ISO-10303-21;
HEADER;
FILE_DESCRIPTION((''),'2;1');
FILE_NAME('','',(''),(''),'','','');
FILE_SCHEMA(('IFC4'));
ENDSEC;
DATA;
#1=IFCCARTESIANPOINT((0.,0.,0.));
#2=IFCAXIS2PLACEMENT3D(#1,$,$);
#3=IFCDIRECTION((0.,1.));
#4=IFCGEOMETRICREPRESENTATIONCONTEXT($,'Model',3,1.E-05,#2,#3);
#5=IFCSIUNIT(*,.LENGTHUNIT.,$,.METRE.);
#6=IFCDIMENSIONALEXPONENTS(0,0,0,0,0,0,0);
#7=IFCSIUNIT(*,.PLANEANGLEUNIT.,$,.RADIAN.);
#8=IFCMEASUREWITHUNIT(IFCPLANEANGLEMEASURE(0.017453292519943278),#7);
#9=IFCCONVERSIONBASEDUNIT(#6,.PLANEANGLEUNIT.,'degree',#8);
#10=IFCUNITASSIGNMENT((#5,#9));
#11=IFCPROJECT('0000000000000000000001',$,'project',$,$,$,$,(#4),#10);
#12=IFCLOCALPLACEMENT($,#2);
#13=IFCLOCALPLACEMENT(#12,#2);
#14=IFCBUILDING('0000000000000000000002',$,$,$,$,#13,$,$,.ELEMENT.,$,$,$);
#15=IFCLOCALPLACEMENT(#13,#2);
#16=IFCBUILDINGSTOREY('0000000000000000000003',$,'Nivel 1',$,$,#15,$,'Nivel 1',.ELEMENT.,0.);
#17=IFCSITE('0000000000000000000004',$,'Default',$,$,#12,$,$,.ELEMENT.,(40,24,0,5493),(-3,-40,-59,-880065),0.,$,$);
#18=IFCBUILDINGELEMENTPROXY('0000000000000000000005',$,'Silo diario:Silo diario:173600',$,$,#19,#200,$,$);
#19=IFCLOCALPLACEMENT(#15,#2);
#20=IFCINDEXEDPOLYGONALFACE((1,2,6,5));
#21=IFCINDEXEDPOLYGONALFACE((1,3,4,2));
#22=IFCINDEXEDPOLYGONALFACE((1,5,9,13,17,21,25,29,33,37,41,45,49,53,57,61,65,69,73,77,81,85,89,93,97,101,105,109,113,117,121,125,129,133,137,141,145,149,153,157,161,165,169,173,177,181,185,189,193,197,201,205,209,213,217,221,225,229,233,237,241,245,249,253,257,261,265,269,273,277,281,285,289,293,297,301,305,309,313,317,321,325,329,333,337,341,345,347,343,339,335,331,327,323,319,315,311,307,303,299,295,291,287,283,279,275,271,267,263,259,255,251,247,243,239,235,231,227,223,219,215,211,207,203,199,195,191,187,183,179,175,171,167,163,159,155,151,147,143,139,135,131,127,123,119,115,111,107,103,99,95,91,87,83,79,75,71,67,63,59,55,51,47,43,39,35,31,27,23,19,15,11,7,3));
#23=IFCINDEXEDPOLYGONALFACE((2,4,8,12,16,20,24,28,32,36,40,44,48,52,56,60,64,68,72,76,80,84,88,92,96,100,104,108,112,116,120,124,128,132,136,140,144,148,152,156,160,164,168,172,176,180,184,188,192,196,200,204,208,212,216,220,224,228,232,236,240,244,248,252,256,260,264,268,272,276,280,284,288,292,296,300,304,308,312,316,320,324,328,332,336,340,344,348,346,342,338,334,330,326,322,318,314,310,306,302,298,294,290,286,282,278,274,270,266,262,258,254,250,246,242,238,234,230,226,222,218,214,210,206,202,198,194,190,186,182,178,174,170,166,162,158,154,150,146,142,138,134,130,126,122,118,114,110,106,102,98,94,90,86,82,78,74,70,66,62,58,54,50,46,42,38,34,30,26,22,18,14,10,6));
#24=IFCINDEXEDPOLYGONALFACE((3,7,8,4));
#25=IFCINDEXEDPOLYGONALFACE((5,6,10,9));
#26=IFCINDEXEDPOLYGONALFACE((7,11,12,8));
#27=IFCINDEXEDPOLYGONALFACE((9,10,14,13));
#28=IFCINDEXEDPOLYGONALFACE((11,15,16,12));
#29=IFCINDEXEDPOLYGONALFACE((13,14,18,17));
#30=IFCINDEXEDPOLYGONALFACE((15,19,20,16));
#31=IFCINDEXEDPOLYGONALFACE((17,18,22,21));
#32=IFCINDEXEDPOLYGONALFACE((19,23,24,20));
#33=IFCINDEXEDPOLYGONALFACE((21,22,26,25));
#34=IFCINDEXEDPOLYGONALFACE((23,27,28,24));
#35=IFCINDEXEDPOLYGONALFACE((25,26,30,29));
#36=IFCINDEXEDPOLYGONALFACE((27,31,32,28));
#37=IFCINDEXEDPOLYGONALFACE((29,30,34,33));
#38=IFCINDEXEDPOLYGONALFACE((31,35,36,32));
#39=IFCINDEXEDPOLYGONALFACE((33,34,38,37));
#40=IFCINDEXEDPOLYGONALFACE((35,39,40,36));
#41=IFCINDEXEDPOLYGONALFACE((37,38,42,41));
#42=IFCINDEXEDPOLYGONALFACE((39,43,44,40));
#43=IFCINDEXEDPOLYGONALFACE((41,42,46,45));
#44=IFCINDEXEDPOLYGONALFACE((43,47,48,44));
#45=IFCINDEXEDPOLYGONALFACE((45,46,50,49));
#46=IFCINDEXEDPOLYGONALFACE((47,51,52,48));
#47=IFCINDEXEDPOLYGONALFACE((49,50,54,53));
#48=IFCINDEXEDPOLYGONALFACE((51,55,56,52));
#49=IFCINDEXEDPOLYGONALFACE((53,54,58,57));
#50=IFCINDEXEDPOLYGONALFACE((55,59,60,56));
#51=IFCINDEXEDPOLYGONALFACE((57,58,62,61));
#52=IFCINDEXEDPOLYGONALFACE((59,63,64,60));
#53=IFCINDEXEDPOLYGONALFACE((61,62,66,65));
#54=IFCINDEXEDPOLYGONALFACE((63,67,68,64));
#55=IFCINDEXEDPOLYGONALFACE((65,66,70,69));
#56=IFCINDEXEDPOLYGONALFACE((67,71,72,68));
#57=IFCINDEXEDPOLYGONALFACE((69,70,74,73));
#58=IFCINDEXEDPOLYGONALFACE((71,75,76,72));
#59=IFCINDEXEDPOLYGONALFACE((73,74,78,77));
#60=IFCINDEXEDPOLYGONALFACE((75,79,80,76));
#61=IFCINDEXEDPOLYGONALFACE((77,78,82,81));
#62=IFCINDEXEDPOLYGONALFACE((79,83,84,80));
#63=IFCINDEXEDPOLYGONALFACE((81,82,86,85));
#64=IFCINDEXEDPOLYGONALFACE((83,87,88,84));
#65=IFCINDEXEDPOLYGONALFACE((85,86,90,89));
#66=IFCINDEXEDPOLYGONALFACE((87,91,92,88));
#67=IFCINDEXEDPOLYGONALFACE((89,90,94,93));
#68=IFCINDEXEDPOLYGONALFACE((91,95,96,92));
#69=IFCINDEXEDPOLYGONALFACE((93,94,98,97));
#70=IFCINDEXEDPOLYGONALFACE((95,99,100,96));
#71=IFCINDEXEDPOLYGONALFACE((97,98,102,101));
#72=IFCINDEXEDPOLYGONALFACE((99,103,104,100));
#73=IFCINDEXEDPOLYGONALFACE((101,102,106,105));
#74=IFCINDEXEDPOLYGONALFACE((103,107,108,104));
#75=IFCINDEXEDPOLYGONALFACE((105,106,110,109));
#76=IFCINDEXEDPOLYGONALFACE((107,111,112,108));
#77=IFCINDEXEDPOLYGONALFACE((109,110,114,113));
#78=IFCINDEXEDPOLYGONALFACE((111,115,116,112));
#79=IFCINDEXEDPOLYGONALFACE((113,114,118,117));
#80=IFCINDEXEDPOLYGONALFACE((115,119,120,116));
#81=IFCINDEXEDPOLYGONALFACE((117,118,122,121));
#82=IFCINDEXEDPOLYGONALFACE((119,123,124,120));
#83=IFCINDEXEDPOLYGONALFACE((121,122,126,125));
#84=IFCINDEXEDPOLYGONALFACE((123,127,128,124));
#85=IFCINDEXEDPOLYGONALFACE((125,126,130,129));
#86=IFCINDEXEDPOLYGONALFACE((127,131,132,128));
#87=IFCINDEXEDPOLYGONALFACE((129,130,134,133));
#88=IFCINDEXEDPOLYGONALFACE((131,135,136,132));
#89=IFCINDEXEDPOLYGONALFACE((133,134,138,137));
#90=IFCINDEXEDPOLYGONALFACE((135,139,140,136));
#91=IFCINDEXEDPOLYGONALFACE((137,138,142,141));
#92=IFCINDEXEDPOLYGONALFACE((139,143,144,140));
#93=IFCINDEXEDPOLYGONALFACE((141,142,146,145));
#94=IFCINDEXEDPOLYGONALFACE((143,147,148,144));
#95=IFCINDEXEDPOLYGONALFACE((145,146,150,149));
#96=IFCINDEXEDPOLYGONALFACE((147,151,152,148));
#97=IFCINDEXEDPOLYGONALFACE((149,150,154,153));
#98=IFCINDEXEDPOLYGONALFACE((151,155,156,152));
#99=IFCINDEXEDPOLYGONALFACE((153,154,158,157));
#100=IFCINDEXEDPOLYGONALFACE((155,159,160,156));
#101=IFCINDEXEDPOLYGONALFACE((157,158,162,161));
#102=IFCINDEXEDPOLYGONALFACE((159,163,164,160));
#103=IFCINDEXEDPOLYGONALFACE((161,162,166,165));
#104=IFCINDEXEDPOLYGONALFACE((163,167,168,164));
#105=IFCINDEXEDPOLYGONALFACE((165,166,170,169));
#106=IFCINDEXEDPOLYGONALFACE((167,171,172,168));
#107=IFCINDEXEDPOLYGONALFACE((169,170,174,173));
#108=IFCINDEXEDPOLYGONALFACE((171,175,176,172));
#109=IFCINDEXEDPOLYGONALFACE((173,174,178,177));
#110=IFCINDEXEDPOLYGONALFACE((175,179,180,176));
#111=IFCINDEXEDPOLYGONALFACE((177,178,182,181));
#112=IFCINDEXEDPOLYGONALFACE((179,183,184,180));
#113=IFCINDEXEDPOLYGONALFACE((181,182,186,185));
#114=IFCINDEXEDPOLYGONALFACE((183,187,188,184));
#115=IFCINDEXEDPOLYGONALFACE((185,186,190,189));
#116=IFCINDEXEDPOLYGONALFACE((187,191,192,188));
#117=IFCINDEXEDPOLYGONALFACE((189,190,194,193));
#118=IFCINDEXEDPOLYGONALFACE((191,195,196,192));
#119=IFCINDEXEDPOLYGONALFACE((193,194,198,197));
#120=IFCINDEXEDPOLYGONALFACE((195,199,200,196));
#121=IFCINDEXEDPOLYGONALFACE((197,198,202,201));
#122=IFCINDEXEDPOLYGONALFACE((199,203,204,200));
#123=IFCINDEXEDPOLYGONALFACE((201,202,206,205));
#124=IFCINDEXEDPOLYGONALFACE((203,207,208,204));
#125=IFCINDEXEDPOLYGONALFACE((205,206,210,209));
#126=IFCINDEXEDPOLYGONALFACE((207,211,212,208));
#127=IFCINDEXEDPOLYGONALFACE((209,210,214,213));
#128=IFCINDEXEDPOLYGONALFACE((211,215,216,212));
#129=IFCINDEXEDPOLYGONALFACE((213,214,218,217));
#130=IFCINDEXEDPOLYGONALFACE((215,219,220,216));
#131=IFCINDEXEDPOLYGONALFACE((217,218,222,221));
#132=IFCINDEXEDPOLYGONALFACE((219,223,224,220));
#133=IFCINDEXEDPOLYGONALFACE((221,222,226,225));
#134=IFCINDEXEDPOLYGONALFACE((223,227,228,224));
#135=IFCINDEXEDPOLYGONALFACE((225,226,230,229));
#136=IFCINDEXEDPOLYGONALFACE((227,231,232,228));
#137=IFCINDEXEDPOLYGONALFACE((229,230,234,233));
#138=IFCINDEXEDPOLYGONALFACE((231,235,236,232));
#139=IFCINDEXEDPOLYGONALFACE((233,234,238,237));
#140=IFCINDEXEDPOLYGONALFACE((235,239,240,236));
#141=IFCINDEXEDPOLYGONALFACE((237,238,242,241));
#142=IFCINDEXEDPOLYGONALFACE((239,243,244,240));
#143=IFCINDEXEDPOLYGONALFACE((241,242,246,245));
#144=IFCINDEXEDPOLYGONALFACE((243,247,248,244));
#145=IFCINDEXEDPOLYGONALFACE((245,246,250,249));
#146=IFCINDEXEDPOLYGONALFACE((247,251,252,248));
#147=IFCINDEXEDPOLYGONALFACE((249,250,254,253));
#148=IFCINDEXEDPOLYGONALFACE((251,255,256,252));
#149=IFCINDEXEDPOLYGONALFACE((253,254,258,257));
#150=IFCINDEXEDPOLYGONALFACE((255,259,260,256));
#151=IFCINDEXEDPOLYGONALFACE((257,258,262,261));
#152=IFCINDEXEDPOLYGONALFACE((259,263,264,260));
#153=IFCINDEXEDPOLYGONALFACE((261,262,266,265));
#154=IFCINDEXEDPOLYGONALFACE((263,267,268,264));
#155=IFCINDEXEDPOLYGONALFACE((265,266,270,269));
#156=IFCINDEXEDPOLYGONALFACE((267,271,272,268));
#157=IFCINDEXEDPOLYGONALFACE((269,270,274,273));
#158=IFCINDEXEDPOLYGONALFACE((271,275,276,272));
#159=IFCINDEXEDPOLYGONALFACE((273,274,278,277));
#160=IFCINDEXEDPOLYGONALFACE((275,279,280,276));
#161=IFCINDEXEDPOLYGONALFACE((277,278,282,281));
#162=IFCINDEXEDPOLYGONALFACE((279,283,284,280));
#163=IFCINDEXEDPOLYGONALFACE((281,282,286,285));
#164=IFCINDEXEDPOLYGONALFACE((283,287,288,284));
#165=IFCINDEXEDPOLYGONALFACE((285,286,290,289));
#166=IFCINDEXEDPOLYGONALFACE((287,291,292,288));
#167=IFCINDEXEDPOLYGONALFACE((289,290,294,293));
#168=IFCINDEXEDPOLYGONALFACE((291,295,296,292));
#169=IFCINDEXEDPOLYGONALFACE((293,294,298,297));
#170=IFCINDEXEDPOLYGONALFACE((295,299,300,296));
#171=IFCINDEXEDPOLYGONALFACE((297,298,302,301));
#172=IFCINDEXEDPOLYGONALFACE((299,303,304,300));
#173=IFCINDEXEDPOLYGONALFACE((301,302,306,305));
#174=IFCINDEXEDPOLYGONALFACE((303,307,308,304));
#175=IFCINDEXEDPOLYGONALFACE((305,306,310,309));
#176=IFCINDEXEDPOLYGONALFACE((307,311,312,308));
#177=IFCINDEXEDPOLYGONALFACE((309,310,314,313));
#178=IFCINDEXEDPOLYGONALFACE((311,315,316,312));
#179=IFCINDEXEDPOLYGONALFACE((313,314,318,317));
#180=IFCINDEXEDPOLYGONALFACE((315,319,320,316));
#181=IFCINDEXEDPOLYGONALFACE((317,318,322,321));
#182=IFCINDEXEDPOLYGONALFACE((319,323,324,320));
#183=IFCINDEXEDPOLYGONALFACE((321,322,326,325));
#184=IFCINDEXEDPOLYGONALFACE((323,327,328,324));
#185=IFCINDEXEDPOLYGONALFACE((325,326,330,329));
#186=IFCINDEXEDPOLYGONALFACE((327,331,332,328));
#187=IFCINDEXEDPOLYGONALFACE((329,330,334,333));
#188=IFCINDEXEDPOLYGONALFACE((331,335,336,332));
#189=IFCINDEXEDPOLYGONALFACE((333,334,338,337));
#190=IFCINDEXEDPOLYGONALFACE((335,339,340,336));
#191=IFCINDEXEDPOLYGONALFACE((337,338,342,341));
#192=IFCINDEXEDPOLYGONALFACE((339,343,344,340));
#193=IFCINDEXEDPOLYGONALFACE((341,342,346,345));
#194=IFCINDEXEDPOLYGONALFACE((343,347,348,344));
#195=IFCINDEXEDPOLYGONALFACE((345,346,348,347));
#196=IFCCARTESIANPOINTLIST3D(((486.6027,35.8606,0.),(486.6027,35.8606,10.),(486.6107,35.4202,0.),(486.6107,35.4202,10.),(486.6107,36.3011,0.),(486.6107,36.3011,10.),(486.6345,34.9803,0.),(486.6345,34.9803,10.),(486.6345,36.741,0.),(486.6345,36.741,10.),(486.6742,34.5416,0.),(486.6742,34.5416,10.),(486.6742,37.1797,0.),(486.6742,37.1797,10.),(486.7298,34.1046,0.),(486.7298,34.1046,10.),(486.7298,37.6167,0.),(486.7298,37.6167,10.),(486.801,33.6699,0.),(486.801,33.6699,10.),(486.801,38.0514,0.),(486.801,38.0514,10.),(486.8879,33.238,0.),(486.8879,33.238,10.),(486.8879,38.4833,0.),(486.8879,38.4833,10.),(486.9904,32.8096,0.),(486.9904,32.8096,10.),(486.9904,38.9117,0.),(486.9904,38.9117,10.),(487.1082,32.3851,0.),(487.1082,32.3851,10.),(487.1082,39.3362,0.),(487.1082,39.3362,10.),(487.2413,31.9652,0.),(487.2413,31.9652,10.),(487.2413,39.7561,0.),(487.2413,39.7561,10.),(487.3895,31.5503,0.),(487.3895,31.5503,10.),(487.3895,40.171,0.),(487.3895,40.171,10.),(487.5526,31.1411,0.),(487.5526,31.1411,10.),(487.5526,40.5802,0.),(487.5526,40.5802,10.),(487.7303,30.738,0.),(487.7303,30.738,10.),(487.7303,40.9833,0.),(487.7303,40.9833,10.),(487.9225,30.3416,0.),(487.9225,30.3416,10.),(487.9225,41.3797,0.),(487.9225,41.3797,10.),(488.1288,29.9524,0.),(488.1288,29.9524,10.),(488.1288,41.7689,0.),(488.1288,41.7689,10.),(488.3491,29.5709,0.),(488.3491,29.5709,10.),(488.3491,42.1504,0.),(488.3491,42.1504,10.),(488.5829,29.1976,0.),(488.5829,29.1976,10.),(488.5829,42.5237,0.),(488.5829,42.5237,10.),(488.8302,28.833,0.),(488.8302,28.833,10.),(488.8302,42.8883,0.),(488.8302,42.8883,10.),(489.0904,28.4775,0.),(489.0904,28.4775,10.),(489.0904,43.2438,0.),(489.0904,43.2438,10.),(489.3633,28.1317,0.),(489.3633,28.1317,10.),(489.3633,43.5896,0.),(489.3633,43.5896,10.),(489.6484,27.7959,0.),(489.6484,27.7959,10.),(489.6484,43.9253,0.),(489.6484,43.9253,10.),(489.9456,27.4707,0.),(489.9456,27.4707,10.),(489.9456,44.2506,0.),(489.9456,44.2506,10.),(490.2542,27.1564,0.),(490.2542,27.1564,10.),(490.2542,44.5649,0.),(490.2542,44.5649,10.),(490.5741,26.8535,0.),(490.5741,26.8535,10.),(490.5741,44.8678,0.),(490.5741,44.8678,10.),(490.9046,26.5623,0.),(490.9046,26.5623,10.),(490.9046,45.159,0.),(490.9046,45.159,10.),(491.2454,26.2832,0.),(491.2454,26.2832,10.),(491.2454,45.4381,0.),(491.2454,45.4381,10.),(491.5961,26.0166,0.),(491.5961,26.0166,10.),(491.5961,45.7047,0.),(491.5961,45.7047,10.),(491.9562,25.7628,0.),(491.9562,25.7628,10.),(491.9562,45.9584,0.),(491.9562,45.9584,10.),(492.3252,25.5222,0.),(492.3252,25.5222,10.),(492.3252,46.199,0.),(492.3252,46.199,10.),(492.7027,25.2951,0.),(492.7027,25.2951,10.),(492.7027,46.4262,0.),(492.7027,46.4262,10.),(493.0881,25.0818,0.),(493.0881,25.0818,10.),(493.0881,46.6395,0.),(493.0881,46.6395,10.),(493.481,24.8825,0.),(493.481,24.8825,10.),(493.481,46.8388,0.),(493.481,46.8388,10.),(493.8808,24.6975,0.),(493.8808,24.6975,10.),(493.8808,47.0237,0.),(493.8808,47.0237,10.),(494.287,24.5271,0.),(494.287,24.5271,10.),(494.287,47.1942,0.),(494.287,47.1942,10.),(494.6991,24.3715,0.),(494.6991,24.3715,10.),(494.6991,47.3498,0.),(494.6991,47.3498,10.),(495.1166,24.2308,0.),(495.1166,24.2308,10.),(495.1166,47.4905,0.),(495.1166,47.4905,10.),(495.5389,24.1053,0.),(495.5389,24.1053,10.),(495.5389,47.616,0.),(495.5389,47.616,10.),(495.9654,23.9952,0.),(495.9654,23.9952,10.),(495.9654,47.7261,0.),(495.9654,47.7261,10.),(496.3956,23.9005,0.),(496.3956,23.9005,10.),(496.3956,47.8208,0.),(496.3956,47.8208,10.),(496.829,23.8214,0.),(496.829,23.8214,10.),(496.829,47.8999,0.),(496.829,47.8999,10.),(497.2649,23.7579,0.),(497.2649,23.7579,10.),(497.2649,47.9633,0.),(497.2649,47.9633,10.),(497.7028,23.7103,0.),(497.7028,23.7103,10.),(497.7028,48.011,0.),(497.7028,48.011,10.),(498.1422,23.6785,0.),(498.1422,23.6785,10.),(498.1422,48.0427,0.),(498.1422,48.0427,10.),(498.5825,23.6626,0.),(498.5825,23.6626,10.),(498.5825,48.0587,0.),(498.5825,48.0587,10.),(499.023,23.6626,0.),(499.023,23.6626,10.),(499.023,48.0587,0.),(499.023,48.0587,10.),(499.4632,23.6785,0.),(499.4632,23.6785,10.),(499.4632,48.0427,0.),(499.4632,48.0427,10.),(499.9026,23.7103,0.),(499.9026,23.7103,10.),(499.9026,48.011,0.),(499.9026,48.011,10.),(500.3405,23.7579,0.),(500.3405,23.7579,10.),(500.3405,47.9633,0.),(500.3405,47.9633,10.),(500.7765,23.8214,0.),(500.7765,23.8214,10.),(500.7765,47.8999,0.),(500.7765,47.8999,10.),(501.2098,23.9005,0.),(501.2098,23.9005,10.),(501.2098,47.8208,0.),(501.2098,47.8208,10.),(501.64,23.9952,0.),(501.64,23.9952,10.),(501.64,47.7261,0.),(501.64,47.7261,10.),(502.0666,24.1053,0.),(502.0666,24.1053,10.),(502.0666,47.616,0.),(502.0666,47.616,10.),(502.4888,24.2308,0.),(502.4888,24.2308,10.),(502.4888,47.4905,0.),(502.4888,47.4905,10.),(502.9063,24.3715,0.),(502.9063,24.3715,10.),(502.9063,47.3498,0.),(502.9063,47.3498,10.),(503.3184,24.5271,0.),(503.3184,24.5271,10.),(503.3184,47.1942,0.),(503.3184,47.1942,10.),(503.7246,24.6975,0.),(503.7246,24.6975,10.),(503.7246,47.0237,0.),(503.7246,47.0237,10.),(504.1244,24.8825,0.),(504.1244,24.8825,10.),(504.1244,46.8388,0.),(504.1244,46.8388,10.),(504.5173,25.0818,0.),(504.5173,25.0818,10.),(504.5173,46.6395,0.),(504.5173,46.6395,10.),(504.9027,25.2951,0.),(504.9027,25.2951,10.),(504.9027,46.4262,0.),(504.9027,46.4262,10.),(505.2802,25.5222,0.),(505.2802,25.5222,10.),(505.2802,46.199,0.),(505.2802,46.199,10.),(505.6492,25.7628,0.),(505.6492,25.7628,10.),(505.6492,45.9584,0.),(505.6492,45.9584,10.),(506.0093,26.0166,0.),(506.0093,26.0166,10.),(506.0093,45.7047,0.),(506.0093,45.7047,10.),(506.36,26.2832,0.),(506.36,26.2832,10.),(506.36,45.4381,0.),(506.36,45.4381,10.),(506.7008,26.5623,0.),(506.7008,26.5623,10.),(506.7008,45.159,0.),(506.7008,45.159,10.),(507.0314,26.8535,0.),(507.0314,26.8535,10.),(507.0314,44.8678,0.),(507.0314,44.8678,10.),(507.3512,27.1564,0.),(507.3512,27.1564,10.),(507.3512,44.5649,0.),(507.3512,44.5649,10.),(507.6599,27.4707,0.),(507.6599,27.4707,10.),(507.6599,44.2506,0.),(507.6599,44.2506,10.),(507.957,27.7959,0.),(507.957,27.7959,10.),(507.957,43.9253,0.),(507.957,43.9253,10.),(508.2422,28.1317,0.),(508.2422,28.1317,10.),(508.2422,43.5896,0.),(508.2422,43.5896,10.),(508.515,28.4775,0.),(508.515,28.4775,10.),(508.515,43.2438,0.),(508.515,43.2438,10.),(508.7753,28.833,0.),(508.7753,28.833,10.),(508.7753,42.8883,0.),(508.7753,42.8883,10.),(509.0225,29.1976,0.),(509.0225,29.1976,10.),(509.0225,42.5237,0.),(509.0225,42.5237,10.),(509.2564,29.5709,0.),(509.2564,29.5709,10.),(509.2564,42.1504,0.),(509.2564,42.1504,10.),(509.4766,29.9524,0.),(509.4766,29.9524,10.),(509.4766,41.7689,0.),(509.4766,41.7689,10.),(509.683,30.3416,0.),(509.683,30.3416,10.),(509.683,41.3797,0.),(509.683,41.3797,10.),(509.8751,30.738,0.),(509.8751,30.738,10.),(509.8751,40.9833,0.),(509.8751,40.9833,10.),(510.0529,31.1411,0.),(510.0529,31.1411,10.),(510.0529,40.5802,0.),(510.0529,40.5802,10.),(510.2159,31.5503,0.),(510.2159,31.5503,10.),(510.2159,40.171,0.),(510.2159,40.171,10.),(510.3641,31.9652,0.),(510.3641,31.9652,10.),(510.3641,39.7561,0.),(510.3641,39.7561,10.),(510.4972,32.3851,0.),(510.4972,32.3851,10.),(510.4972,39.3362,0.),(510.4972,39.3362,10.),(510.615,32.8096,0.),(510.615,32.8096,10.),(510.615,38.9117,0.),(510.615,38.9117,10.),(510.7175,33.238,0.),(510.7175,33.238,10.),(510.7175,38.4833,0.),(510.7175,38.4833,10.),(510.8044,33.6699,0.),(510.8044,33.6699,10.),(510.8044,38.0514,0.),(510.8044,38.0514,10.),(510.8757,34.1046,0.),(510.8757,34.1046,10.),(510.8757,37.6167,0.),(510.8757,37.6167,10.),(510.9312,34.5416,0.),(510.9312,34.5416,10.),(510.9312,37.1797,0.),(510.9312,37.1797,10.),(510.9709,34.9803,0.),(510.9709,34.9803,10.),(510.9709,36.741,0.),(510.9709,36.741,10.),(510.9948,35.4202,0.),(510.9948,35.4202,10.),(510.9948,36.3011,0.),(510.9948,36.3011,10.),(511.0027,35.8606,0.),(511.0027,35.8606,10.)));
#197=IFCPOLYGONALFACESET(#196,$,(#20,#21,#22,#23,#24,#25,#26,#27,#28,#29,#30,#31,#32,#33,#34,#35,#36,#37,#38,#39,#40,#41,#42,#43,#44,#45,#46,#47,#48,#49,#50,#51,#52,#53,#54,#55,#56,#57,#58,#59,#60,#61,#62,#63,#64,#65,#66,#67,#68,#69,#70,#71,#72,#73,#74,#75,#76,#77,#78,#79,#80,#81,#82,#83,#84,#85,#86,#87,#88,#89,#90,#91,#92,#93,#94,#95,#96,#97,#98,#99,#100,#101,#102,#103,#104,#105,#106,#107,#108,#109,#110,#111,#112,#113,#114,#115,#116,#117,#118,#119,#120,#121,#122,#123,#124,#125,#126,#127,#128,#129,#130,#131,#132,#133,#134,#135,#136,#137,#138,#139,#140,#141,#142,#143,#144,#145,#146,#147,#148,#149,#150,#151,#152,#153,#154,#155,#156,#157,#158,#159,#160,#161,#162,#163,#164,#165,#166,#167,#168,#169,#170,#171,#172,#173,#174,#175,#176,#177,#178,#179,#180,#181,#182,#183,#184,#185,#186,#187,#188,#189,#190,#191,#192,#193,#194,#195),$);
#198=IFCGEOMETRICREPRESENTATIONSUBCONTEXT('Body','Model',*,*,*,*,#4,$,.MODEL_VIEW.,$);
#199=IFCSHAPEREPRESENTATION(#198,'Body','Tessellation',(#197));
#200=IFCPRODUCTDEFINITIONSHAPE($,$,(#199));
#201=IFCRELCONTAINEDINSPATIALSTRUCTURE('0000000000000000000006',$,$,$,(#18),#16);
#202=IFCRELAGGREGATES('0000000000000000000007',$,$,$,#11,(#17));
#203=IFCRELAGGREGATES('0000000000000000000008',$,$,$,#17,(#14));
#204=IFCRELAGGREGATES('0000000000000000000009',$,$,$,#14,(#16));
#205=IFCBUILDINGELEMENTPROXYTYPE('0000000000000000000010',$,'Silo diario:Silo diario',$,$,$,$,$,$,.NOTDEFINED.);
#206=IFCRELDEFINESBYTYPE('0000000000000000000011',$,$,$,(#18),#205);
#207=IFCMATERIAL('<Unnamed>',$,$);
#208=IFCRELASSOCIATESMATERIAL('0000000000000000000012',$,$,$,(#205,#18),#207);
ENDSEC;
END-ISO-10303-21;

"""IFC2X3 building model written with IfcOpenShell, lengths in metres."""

from ifc_helpers import new_model, entity, si_unit, converted_unit, direction, frame, frame_2d, origin, place, context, subcontext, project, spatial, circle, extrude, source, transform, mapped, material, type_object, type_shapes, element, save


model = new_model("IFC2X3")

# Units and contexts
model_context = context("Model", 3, precision=1e-05, world=origin(), true_north=direction((0.0, 1.0)))
body_context = subcontext(model_context, "Body", "Model", "MODEL_VIEW")
ifc_project = project(units=[si_unit("LENGTHUNIT", "METRE"), converted_unit("PLANEANGLEUNIT", "degree", entity("IfcPlaneAngleMeasure", 0.017453292519943278), si_unit("PLANEANGLEUNIT", "RADIAN"), dimensions=[0, 0, 0, 0, 0, 0, 0])], contexts=[model_context])

# Site, building, storey
site_placement = place(None, origin())
site = spatial("IfcSite", under=ifc_project, at=site_placement, Name="Default", CompositionType="ELEMENT", RefLatitude=(40, 24, 0, 5493), RefLongitude=(-3, -40, -59, -880065), RefElevation=0.0)
building_placement = place(site_placement, origin())
building = spatial("IfcBuilding", under=site, at=building_placement, CompositionType="ELEMENT")
storey_placement = place(building_placement, origin())
storey = spatial("IfcBuildingStorey", under=building, at=storey_placement, Name="Nivel 1", LongName="Nivel 1", CompositionType="ELEMENT", Elevation=0.0)

# Building element proxy
ifc_material_1 = material(Name="<Unnamed>")
building_element_proxy_type_1 = type_object("IfcBuildingElementProxyType", Name="Silo diario:Silo diario", PredefinedType="NOTDEFINED", material=ifc_material_1)
shared_shape_1 = source(origin(), body_context, "Body", "SweptSolid", [
    extrude(circle(Radius=12.2, at=frame_2d((0.0, 0.0), x_axis=(1.0, 0.0))), frame((498.8027, 35.8606, 0.0)), (0.0, 0.0, 1.0), 10.0),
])
type_shapes(building_element_proxy_type_1, [shared_shape_1])
proxy_1_placement = place(storey_placement, origin())
element("IfcBuildingElementProxy", 1, at=proxy_1_placement, inside=storey, type_object=building_element_proxy_type_1, material=ifc_material_1, Name="Silo diario:Silo diario:173600", context=body_context, shape_type="MappedRepresentation", body=[
    mapped(shared_shape_1, transform((0.0, 0.0, 0.0), scale=1.0)),
])

save(model, "model.ifc")
